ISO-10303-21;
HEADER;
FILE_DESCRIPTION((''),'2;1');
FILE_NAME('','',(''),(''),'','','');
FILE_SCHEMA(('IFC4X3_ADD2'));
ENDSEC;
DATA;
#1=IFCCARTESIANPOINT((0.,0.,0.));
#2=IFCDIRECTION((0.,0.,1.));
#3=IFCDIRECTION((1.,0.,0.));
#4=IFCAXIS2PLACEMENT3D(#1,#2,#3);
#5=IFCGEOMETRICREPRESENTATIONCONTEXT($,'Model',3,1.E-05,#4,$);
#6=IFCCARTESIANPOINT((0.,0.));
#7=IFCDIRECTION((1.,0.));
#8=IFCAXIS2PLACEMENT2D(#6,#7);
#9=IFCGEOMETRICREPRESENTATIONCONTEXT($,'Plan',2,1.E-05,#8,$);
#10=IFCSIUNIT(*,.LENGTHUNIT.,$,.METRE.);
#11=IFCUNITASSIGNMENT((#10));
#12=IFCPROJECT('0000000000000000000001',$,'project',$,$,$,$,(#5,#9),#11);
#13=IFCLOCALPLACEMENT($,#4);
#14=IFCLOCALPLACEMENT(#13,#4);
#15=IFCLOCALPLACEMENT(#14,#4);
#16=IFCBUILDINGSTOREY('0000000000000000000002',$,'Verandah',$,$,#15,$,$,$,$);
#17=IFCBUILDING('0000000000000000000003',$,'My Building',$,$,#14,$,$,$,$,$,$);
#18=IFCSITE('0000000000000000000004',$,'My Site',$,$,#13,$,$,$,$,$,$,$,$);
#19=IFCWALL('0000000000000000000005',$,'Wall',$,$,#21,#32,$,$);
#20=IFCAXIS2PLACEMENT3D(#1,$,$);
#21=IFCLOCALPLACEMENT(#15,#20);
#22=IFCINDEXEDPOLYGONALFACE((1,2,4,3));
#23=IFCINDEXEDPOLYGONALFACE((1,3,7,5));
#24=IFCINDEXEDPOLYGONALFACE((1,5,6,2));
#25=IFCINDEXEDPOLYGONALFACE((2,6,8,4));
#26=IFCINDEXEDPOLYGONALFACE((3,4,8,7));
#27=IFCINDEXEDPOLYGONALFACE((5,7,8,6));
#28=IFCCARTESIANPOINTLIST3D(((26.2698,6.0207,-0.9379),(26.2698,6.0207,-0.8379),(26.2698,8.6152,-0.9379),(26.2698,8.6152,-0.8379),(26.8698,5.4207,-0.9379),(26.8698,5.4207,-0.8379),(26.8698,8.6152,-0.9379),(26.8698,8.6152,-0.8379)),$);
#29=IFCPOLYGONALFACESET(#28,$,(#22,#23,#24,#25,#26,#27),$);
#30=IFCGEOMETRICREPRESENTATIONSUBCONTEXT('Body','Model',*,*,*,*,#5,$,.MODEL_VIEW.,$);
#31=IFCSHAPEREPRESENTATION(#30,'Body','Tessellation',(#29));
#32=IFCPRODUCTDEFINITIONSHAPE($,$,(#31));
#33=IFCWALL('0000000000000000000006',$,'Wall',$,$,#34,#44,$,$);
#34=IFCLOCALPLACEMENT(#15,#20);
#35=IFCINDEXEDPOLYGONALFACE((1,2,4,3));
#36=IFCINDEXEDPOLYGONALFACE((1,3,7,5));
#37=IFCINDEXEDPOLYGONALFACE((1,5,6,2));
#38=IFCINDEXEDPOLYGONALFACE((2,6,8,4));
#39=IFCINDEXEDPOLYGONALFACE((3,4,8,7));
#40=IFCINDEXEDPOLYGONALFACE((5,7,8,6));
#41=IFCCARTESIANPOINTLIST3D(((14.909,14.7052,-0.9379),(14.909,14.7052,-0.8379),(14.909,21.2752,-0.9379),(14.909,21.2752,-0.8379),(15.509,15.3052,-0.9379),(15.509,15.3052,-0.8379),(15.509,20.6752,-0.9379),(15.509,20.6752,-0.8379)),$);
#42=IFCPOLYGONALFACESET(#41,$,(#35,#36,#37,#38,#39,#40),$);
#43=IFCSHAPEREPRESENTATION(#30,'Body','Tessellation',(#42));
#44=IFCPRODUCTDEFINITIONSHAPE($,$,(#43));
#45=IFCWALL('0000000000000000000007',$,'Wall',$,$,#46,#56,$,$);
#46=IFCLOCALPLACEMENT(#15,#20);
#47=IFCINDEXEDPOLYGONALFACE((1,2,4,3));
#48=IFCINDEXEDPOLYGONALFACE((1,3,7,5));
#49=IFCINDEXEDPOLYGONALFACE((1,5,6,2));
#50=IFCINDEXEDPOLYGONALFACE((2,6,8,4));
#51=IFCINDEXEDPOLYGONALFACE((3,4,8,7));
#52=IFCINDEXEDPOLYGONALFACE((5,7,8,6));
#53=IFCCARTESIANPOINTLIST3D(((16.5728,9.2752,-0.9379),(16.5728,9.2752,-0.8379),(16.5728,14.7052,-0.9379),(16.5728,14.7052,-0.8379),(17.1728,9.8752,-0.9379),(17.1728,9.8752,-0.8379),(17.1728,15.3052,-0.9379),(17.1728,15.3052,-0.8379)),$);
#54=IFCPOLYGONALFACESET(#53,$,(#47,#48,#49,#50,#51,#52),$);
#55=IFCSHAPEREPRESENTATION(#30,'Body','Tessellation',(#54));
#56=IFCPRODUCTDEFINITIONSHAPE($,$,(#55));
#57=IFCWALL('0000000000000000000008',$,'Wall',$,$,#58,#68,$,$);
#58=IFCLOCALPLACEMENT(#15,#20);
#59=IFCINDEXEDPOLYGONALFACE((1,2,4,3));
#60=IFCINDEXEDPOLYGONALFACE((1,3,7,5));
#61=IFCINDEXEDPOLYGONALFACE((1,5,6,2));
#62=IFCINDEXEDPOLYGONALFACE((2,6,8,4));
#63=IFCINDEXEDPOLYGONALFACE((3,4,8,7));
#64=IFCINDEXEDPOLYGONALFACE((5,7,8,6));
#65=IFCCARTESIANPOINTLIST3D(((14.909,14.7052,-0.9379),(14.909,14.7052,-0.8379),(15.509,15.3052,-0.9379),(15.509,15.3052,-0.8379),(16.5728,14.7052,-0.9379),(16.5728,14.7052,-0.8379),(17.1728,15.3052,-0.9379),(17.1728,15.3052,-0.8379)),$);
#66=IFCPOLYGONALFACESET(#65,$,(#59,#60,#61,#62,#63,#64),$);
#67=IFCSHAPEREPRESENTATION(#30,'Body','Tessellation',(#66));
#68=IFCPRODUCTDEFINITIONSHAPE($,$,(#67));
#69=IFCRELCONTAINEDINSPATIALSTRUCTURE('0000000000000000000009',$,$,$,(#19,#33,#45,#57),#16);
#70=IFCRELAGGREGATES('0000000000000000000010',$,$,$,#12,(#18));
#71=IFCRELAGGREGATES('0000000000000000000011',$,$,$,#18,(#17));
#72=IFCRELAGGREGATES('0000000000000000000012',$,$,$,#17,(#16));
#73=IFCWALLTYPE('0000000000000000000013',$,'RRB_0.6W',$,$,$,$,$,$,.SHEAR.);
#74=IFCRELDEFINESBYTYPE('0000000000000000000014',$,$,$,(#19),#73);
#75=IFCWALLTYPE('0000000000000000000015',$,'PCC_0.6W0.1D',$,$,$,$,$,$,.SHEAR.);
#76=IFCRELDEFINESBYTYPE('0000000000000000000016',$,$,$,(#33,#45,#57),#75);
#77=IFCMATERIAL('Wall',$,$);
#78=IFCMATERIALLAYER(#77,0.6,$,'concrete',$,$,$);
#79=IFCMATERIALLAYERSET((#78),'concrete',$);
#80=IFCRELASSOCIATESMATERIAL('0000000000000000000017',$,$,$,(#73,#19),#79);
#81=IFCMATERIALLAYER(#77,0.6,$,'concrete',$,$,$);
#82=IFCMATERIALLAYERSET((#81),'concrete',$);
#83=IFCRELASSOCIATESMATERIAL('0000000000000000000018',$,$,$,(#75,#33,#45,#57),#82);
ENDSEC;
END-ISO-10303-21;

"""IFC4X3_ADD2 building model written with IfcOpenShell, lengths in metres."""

from ifc_helpers import new_model, si_unit, frame, origin_with_axes, origin_2d_with_axis, place, context, subcontext, project, spatial, line, indexed_curve, outline, extrude, material, layer, layer_set, layer_usage, type_object, element, save


model = new_model("IFC4X3_ADD2")

# Units and contexts
model_context = context("Model", 3, precision=1e-05, world=origin_with_axes())
plan_context = context("Plan", 2, precision=1e-05, world=origin_2d_with_axis())
body_context = subcontext(model_context, "Body", "Model", "MODEL_VIEW")
ifc_project = project(units=[si_unit("LENGTHUNIT", "METRE")], contexts=[model_context, plan_context])

# Site, building, storey
site_placement = place(None, origin_with_axes())
site = spatial("IfcSite", under=ifc_project, at=site_placement, Name="My Site")
building_placement = place(site_placement, origin_with_axes())
building = spatial("IfcBuilding", under=site, at=building_placement, Name="My Building")
storey_placement = place(building_placement, origin_with_axes())
storey = spatial("IfcBuildingStorey", under=building, at=storey_placement, Name="Verandah")

# Walls
ifc_material_1 = material(Name="Wall")
ifc_layer_1 = layer(ifc_material_1, 0.6, Name="concrete")
ifc_layer_set_1 = layer_set([ifc_layer_1], Name="concrete")
wall_type_1 = type_object("IfcWallType", Name="RRB_0.6W", PredefinedType="SHEAR", material=ifc_layer_set_1)
ifc_layer_usage_1 = layer_usage(ifc_layer_set_1, "AXIS2", "POSITIVE", 0.0)
wall_1_placement = place(storey_placement, frame((26.8698, 6.0207, -0.9379), z_axis=(0.0, 0.0, 1.0), x_axis=(0.000001, 1.0, 0.0)))
element("IfcWall", 1, at=wall_1_placement, inside=storey, type_object=wall_type_1, material=ifc_layer_usage_1, Name="Wall", context=body_context, shape_type="SweptSolid", body=[
    extrude(outline(indexed_curve([(-0.6, 0.0), (0.0, 0.6), (2.5945, 0.6), (2.5945, 0.0)], segments=[line(1, 2, 3, 4, 1)])), origin_with_axes(), (0.0, 0.0, 1.0), 0.1),
])
ifc_layer_2 = layer(ifc_material_1, 0.6, Name="concrete")
ifc_layer_set_2 = layer_set([ifc_layer_2], Name="concrete")
ifc_layer_usage_2 = layer_usage(ifc_layer_set_2, "AXIS2", "POSITIVE", 0.0)
wall_type_2 = type_object("IfcWallType", Name="PCC_0.6W0.1D", PredefinedType="SHEAR", material=ifc_layer_set_2)
wall_2_placement = place(storey_placement, frame((15.509, 15.3052, -0.9379), z_axis=(0.0, 0.0, 1.0), x_axis=(0.000001, 1.0, 0.0)))
element("IfcWall", 2, at=wall_2_placement, inside=storey, type_object=wall_type_2, material=ifc_layer_usage_2, Name="Wall", context=body_context, shape_type="SweptSolid", body=[
    extrude(outline(indexed_curve([(0.0, 0.0), (-0.6, 0.6), (5.97, 0.6), (5.37, 0.0)], segments=[line(1, 2, 3, 4, 1)])), origin_with_axes(), (0.0, 0.0, 1.0), 0.1),
])
ifc_layer_usage_3 = layer_usage(ifc_layer_set_2, "AXIS2", "POSITIVE", 0.0)
wall_3_placement = place(storey_placement, frame((17.1728, 9.8752, -0.9379), z_axis=(0.0, 0.0, 1.0), x_axis=(0.000001, 1.0, 0.0)))
element("IfcWall", 3, at=wall_3_placement, inside=storey, type_object=wall_type_2, material=ifc_layer_usage_3, Name="Wall", context=body_context, shape_type="SweptSolid", body=[
    extrude(outline(indexed_curve([(0.0, 0.0), (-0.6, 0.6), (4.83, 0.6), (5.43, 0.0)], segments=[line(1, 2, 3, 4, 1)])), origin_with_axes(), (0.0, 0.0, 1.0), 0.1),
])
ifc_layer_usage_4 = layer_usage(ifc_layer_set_2, "AXIS2", "POSITIVE", 0.0)
wall_4_placement = place(storey_placement, frame((17.1728, 15.3052, -0.9379), z_axis=(0.0, 0.0, 1.0), x_axis=(-1.0, 0.000001, 0.0)))
element("IfcWall", 4, at=wall_4_placement, inside=storey, type_object=wall_type_2, material=ifc_layer_usage_4, Name="Wall", context=body_context, shape_type="SweptSolid", body=[
    extrude(outline(indexed_curve([(0.0, 0.0), (0.6, 0.6), (2.2638, 0.6), (1.6638, 0.0)], segments=[line(1, 2, 3, 4, 1)])), origin_with_axes(), (0.0, 0.0, 1.0), 0.1),
])

save(model, "model.ifc")
